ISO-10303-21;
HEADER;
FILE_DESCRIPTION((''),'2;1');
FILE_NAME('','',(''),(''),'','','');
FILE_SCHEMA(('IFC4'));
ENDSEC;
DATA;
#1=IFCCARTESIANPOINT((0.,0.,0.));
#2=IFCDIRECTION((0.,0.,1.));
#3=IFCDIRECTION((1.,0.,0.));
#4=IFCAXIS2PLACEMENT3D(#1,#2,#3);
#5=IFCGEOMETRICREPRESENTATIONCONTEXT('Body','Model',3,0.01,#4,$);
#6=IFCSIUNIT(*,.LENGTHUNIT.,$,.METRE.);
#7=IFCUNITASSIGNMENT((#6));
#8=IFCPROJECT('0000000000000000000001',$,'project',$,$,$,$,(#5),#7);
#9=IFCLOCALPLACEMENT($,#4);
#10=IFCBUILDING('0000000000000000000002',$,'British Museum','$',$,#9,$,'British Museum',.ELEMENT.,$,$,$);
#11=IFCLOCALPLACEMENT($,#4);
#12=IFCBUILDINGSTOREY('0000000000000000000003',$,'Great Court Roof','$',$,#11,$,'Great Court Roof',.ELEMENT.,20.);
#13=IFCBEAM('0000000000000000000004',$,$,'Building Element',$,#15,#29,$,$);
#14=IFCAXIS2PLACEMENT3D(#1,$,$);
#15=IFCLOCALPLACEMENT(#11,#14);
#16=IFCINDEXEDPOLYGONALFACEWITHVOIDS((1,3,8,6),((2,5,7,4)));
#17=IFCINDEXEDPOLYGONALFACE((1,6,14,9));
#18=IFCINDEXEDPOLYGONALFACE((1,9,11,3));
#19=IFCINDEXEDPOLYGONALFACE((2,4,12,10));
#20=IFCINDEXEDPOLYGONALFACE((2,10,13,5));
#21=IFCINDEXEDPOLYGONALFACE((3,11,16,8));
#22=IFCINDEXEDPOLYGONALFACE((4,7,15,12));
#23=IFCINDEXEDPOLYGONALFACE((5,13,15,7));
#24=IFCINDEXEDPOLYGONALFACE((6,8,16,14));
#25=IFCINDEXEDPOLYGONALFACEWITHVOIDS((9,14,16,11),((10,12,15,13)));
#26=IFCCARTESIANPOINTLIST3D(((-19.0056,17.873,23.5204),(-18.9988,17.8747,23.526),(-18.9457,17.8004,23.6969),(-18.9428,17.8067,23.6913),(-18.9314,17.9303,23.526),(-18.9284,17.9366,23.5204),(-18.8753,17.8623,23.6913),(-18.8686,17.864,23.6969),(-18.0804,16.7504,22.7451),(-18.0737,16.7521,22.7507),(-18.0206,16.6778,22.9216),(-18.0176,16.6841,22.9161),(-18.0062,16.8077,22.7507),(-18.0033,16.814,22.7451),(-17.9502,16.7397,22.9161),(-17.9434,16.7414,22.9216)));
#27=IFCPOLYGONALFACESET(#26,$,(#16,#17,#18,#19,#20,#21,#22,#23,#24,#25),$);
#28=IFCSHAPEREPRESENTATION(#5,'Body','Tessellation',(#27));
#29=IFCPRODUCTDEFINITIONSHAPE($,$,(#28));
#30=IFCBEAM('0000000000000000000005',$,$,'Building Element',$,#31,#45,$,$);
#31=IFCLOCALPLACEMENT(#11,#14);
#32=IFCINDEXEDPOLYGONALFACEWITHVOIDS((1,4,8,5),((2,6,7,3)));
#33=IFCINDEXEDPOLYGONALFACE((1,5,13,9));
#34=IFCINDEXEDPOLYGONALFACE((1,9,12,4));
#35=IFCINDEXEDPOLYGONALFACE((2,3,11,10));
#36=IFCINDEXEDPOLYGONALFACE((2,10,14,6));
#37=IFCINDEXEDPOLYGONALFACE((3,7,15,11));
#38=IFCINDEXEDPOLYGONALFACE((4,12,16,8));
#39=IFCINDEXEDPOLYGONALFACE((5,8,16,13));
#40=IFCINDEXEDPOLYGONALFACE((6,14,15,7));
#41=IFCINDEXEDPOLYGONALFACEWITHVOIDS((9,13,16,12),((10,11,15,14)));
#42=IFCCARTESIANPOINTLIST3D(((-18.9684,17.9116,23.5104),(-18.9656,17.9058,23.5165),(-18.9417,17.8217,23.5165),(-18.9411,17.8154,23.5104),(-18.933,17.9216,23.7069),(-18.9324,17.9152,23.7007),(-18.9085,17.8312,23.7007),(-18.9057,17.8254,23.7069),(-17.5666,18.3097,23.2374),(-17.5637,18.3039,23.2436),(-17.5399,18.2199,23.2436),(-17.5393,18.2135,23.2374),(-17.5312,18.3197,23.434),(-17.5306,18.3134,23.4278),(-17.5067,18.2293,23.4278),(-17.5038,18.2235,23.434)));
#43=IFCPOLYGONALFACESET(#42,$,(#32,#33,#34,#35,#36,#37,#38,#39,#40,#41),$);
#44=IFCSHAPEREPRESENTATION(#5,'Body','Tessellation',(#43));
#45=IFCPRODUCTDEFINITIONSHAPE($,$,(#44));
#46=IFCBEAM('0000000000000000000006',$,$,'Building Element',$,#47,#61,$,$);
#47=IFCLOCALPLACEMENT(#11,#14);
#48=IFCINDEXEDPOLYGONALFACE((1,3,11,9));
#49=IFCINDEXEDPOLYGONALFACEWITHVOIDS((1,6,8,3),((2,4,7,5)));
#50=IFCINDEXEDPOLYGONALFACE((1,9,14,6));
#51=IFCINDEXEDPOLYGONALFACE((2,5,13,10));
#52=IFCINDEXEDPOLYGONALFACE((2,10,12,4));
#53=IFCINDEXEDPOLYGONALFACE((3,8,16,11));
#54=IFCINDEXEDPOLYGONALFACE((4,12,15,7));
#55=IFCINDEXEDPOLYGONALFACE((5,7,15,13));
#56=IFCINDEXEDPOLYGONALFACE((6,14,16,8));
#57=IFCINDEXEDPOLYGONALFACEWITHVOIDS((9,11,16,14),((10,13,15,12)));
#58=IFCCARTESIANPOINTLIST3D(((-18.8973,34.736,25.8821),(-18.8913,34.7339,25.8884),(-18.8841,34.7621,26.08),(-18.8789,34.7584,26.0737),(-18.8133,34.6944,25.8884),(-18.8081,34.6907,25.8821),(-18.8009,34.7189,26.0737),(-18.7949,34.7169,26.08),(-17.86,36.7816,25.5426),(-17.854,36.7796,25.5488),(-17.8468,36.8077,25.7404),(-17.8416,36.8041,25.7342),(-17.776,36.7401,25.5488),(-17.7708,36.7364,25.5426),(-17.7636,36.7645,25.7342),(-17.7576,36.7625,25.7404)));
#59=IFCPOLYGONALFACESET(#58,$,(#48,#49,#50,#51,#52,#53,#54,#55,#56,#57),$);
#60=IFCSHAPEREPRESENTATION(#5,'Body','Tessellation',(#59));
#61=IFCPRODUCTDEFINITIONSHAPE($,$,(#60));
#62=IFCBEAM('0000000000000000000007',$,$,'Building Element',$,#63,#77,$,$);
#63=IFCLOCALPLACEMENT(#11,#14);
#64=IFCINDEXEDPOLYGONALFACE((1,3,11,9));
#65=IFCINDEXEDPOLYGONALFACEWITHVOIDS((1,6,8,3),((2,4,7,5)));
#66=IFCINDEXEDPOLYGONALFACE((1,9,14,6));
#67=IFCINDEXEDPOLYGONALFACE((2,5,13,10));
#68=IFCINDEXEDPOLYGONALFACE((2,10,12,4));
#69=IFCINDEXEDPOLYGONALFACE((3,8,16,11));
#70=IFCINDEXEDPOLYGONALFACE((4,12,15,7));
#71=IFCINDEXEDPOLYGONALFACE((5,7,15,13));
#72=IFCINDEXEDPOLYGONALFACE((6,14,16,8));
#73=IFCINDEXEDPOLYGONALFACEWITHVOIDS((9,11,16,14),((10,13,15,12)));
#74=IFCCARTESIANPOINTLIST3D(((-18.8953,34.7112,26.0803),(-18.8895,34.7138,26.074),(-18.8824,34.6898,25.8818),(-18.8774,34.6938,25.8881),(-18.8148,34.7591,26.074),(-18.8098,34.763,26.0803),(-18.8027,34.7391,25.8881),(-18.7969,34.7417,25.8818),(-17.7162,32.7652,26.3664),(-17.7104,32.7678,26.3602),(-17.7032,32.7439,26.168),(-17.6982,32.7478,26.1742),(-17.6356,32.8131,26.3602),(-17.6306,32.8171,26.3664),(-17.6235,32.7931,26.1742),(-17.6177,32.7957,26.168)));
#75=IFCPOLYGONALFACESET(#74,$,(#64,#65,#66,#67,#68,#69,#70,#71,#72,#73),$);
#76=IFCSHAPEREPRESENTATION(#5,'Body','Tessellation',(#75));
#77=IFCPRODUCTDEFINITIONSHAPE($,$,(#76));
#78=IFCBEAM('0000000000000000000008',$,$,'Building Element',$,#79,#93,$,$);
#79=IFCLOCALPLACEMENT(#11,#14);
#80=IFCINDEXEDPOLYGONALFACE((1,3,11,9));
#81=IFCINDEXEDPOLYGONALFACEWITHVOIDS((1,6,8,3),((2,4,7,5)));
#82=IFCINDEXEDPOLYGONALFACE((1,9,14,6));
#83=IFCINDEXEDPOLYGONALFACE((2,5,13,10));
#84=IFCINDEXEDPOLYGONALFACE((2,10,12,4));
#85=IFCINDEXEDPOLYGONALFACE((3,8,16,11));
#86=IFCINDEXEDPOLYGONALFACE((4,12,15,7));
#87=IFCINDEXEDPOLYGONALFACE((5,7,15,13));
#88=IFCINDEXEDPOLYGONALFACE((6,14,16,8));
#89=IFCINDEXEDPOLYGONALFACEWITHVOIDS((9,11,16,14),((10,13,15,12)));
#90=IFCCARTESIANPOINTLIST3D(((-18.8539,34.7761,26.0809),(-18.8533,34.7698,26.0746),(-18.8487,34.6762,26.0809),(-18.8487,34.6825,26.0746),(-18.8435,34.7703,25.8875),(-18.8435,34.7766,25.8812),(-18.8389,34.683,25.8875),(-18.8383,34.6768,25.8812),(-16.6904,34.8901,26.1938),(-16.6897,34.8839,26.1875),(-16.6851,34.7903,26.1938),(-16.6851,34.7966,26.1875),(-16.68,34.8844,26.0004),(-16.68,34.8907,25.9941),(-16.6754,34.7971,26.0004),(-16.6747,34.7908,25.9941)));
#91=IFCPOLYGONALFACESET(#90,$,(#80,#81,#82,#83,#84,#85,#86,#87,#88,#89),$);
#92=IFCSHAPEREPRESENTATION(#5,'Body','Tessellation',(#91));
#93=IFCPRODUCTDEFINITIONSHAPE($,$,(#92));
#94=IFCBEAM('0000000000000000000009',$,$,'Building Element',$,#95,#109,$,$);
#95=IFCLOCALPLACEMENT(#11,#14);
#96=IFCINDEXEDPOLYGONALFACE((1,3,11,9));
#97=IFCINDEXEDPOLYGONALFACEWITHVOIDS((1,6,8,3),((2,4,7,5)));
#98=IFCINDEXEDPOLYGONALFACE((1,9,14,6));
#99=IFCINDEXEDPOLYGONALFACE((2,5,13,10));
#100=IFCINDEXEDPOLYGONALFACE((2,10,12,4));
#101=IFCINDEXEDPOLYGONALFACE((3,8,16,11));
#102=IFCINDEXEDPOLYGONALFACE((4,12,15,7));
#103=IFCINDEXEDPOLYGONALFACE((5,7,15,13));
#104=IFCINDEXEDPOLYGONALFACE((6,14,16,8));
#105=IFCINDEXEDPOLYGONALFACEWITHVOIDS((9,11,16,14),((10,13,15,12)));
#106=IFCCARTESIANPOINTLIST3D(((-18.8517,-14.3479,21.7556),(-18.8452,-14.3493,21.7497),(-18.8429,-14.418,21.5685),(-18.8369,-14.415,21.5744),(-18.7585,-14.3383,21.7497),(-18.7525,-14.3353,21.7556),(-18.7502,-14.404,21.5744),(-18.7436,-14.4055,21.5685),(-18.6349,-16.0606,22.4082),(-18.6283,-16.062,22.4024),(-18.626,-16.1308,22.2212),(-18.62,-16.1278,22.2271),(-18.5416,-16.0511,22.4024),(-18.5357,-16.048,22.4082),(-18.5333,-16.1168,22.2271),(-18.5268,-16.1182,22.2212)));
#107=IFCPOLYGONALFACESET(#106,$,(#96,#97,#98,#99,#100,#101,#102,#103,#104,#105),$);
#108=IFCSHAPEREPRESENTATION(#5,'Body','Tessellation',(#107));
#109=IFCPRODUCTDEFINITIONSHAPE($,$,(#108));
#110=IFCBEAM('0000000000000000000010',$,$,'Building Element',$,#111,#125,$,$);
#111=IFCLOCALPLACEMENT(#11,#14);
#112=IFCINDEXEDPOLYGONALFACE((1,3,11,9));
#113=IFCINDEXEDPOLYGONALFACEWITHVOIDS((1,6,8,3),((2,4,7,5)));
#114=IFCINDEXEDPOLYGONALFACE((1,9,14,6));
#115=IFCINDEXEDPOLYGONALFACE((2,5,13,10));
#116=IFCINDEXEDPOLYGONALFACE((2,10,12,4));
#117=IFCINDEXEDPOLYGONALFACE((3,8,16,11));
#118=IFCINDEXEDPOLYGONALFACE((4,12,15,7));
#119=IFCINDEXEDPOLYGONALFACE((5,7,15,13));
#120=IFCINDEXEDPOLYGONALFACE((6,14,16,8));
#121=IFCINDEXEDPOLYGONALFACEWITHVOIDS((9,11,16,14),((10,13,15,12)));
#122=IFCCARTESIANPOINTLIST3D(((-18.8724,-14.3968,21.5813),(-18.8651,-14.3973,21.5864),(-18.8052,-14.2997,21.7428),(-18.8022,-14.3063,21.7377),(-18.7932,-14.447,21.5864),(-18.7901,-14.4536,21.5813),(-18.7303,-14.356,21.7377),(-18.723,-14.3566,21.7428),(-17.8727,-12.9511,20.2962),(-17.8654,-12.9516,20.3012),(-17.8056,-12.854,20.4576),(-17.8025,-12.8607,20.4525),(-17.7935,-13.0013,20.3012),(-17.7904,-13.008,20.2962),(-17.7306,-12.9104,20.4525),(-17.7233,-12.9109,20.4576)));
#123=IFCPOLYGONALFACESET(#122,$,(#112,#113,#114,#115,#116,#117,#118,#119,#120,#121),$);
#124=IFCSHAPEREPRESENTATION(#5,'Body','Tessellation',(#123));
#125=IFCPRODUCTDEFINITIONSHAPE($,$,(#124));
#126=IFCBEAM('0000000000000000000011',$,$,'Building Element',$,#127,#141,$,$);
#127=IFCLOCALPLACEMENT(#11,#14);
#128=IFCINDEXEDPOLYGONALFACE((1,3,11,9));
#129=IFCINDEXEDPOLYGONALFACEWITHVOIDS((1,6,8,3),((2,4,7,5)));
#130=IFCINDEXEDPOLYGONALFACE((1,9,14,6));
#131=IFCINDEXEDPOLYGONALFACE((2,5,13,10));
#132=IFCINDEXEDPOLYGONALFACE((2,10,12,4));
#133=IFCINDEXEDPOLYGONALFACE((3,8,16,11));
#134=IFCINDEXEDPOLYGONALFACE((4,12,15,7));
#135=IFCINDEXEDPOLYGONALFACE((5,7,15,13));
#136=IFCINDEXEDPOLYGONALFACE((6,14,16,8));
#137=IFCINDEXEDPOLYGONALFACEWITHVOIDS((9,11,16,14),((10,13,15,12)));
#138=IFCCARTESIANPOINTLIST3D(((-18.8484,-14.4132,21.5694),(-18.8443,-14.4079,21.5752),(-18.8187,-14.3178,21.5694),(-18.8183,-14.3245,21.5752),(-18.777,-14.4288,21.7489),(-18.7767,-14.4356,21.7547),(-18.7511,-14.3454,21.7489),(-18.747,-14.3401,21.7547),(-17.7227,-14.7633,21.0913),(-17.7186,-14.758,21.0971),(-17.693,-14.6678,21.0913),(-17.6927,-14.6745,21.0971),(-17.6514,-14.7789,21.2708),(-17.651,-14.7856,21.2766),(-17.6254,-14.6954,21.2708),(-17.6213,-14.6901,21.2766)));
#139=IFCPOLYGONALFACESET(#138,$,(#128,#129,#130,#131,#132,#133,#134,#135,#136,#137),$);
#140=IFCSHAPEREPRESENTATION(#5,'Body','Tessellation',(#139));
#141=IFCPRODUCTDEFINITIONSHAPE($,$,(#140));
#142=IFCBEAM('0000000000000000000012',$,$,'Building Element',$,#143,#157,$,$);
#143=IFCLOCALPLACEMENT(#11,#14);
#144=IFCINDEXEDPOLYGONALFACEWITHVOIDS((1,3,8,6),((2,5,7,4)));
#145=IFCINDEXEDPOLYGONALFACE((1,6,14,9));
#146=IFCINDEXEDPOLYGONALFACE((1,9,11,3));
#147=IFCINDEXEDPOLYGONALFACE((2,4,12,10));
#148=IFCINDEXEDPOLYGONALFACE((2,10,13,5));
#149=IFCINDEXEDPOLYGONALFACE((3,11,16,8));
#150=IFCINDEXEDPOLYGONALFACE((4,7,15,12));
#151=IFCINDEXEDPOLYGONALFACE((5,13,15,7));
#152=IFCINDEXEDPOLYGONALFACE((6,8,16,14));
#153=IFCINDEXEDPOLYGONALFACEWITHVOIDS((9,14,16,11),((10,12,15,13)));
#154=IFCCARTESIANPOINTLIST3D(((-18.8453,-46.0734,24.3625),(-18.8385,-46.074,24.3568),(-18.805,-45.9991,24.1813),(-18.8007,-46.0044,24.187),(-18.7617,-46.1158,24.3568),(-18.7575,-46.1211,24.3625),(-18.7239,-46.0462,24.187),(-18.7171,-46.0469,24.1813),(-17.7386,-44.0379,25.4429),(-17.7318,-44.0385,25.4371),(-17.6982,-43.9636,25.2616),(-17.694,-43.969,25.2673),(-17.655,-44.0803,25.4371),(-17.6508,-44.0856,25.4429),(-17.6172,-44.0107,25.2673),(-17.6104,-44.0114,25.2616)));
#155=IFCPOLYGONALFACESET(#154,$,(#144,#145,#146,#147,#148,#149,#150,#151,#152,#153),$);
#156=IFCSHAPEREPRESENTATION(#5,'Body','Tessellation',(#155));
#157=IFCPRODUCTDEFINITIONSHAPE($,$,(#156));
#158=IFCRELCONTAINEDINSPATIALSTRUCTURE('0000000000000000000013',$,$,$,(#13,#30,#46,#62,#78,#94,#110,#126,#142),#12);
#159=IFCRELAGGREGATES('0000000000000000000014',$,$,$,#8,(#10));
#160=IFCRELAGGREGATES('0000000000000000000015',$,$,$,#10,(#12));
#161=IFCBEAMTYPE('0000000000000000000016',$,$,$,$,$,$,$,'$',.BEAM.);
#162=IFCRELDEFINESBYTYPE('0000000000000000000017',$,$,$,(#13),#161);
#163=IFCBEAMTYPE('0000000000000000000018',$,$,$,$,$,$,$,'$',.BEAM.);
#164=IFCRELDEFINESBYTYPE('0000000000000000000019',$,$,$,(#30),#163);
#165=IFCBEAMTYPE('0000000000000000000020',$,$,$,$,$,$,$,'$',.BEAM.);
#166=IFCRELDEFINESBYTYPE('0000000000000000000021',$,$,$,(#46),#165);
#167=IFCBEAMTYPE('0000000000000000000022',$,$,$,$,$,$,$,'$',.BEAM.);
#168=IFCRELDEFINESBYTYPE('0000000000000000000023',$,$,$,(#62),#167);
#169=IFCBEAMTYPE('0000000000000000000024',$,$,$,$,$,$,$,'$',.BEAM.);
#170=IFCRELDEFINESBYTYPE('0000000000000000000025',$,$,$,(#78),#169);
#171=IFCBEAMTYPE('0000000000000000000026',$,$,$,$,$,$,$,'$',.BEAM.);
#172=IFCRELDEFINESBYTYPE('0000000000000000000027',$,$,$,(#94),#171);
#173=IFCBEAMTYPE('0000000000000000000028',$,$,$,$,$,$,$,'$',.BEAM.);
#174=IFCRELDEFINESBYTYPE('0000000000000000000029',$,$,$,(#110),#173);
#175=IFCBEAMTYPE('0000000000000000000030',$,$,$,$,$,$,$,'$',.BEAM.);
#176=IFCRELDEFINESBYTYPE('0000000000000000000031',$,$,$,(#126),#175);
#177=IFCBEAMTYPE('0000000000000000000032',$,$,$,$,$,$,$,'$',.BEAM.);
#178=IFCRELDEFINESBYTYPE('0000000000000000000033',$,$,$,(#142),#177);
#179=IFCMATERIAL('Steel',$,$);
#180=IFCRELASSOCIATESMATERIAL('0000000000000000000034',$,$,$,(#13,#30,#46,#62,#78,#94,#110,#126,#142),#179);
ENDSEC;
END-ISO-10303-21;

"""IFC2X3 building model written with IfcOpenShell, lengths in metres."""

from ifc_helpers import new_model, si_unit, frame, origin_with_axes, origin_2d, place, context, project, spatial, hollow_rectangle, extrude, material, type_object, element, save


model = new_model("IFC2X3")

# Units and contexts
model_context = context("Model", 3, precision=0.01, world=origin_with_axes(), identifier="Body")
ifc_project = project(units=[si_unit("LENGTHUNIT", "METRE")], contexts=[model_context])

# Building, storey
building_placement = place(None, origin_with_axes())
building = spatial("IfcBuilding", under=ifc_project, at=building_placement, Name="British Museum", Description="$", LongName="British Museum", CompositionType="ELEMENT")
storey_placement = place(None, origin_with_axes())
storey = spatial("IfcBuildingStorey", under=building, at=storey_placement, Name="Great Court Roof", Description="$", LongName="Great Court Roof", CompositionType="ELEMENT", Elevation=20.0)

# Beams
ifc_material = material(Name="Steel")
beam_type_1 = type_object("IfcBeamType", ElementType="$", PredefinedType="BEAM")
beam_1_placement = place(None, origin_with_axes())
element("IfcBeam", 1, at=beam_1_placement, inside=storey, type_object=beam_type_1, material=ifc_material, Description="Building Element", context=model_context, shape_type="SweptSolid", body=[
    extrude(hollow_rectangle(XDim=0.1, YDim=0.2, WallThickness=0.0063, InnerFilletRadius=-0.0063, OuterFilletRadius=0.0, at=origin_2d()), frame((-18.9371, 17.8685, 23.6086), z_axis=(0.561242, -0.681024, -0.470334), x_axis=(0.771709, 0.635976, 0.0)), (0.0, 0.0, 1.0), 1.6484),
])
beam_type_2 = type_object("IfcBeamType", ElementType="$", PredefinedType="BEAM")
beam_2_placement = place(None, origin_with_axes())
element("IfcBeam", 2, at=beam_2_placement, inside=storey, type_object=beam_type_2, material=ifc_material, Description="Building Element", context=model_context, shape_type="SweptSolid", body=[
    extrude(hollow_rectangle(XDim=0.1, YDim=0.2, WallThickness=0.0063, InnerFilletRadius=-0.0063, OuterFilletRadius=0.0, at=origin_2d()), frame((-18.9371, 17.8685, 23.6086), z_axis=(0.945521, 0.268529, -0.184071), x_axis=(-0.273197, 0.961958, 0.0)), (0.0, 0.0, 1.0), 1.4826),
])
beam_type_3 = type_object("IfcBeamType", ElementType="$", PredefinedType="BEAM")
beam_3_placement = place(None, origin_with_axes())
element("IfcBeam", 3, at=beam_3_placement, inside=storey, type_object=beam_type_3, material=ifc_material, Description="Building Element", context=model_context, shape_type="SweptSolid", body=[
    extrude(hollow_rectangle(XDim=0.1, YDim=0.2, WallThickness=0.0063, InnerFilletRadius=-0.0063, OuterFilletRadius=0.0, at=origin_2d()), frame((-18.8461, 34.7264, 25.981), z_axis=(0.447376, 0.882273, -0.146451), x_axis=(-0.89189, 0.452252, 0.0)), (0.0, 0.0, 1.0), 2.3186),
])
beam_type_4 = type_object("IfcBeamType", ElementType="$", PredefinedType="BEAM")
beam_4_placement = place(None, origin_with_axes())
element("IfcBeam", 4, at=beam_4_placement, inside=storey, type_object=beam_type_4, material=ifc_material, Description="Building Element", context=model_context, shape_type="SweptSolid", body=[
    extrude(hollow_rectangle(XDim=0.1, YDim=0.2, WallThickness=0.0063, InnerFilletRadius=-0.0063, OuterFilletRadius=0.0, at=origin_2d()), frame((-18.8461, 34.7264, 25.981), z_axis=(0.514188, -0.848551, 0.124783), x_axis=(0.855236, 0.518239, 0.0)), (0.0, 0.0, 1.0), 2.2933),
])
beam_type_5 = type_object("IfcBeamType", ElementType="$", PredefinedType="BEAM")
beam_5_placement = place(None, origin_with_axes())
element("IfcBeam", 5, at=beam_5_placement, inside=storey, type_object=beam_type_5, material=ifc_material, Description="Building Element", context=model_context, shape_type="SweptSolid", body=[
    extrude(hollow_rectangle(XDim=0.1, YDim=0.2, WallThickness=0.0063, InnerFilletRadius=-0.0063, OuterFilletRadius=0.0, at=origin_2d()), frame((-18.8461, 34.7264, 25.981), z_axis=(0.99726, 0.052584, 0.052038), x_axis=(-0.052655, 0.998613, 0.0)), (0.0, 0.0, 1.0), 2.1695),
])
beam_type_6 = type_object("IfcBeamType", ElementType="$", PredefinedType="BEAM")
beam_6_placement = place(None, origin_with_axes())
element("IfcBeam", 6, at=beam_6_placement, inside=storey, type_object=beam_type_6, material=ifc_material, Description="Building Element", context=model_context, shape_type="SweptSolid", body=[
    extrude(hollow_rectangle(XDim=0.1, YDim=0.2, WallThickness=0.0063, InnerFilletRadius=-0.0063, OuterFilletRadius=0.0, at=origin_2d()), frame((-18.7977, -14.3767, 21.662), z_axis=(0.1175, -0.927981, 0.353618), x_axis=(0.992079, 0.125616, 0.0)), (0.0, 0.0, 1.0), 1.8457),
])
beam_type_7 = type_object("IfcBeamType", ElementType="$", PredefinedType="BEAM")
beam_7_placement = place(None, origin_with_axes())
element("IfcBeam", 7, at=beam_7_placement, inside=storey, type_object=beam_type_7, material=ifc_material, Description="Building Element", context=model_context, shape_type="SweptSolid", body=[
    extrude(hollow_rectangle(XDim=0.1, YDim=0.2, WallThickness=0.0063, InnerFilletRadius=-0.0063, OuterFilletRadius=0.0, at=origin_2d()), frame((-18.7977, -14.3767, 21.662), z_axis=(0.459128, 0.663947, -0.590234), x_axis=(-0.822498, 0.568768, 0.0)), (0.0, 0.0, 1.0), 2.1774),
])
beam_type_8 = type_object("IfcBeamType", ElementType="$", PredefinedType="BEAM")
beam_8_placement = place(None, origin_with_axes())
element("IfcBeam", 8, at=beam_8_placement, inside=storey, type_object=beam_type_8, material=ifc_material, Description="Building Element", context=model_context, shape_type="SweptSolid", body=[
    extrude(hollow_rectangle(XDim=0.1, YDim=0.2, WallThickness=0.0063, InnerFilletRadius=-0.0063, OuterFilletRadius=0.0, at=origin_2d()), frame((-18.7977, -14.3767, 21.662), z_axis=(0.884904, -0.275158, -0.37581), x_axis=(0.296924, 0.954901, 0.0)), (0.0, 0.0, 1.0), 1.2721),
])
beam_type_9 = type_object("IfcBeamType", ElementType="$", PredefinedType="BEAM")
beam_9_placement = place(None, origin_with_axes())
element("IfcBeam", 9, at=beam_9_placement, inside=storey, type_object=beam_type_9, material=ifc_material, Description="Building Element", context=model_context, shape_type="SweptSolid", body=[
    extrude(hollow_rectangle(XDim=0.1, YDim=0.2, WallThickness=0.0063, InnerFilletRadius=-0.0063, OuterFilletRadius=0.0, at=origin_2d()), frame((-18.7812, -46.0601, 24.2719), z_axis=(0.43292, 0.796236, 0.422598), x_axis=(-0.87854, 0.477669, 0.0)), (0.0, 0.0, 1.0), 2.5564),
])

save(model, "model.ifc")
